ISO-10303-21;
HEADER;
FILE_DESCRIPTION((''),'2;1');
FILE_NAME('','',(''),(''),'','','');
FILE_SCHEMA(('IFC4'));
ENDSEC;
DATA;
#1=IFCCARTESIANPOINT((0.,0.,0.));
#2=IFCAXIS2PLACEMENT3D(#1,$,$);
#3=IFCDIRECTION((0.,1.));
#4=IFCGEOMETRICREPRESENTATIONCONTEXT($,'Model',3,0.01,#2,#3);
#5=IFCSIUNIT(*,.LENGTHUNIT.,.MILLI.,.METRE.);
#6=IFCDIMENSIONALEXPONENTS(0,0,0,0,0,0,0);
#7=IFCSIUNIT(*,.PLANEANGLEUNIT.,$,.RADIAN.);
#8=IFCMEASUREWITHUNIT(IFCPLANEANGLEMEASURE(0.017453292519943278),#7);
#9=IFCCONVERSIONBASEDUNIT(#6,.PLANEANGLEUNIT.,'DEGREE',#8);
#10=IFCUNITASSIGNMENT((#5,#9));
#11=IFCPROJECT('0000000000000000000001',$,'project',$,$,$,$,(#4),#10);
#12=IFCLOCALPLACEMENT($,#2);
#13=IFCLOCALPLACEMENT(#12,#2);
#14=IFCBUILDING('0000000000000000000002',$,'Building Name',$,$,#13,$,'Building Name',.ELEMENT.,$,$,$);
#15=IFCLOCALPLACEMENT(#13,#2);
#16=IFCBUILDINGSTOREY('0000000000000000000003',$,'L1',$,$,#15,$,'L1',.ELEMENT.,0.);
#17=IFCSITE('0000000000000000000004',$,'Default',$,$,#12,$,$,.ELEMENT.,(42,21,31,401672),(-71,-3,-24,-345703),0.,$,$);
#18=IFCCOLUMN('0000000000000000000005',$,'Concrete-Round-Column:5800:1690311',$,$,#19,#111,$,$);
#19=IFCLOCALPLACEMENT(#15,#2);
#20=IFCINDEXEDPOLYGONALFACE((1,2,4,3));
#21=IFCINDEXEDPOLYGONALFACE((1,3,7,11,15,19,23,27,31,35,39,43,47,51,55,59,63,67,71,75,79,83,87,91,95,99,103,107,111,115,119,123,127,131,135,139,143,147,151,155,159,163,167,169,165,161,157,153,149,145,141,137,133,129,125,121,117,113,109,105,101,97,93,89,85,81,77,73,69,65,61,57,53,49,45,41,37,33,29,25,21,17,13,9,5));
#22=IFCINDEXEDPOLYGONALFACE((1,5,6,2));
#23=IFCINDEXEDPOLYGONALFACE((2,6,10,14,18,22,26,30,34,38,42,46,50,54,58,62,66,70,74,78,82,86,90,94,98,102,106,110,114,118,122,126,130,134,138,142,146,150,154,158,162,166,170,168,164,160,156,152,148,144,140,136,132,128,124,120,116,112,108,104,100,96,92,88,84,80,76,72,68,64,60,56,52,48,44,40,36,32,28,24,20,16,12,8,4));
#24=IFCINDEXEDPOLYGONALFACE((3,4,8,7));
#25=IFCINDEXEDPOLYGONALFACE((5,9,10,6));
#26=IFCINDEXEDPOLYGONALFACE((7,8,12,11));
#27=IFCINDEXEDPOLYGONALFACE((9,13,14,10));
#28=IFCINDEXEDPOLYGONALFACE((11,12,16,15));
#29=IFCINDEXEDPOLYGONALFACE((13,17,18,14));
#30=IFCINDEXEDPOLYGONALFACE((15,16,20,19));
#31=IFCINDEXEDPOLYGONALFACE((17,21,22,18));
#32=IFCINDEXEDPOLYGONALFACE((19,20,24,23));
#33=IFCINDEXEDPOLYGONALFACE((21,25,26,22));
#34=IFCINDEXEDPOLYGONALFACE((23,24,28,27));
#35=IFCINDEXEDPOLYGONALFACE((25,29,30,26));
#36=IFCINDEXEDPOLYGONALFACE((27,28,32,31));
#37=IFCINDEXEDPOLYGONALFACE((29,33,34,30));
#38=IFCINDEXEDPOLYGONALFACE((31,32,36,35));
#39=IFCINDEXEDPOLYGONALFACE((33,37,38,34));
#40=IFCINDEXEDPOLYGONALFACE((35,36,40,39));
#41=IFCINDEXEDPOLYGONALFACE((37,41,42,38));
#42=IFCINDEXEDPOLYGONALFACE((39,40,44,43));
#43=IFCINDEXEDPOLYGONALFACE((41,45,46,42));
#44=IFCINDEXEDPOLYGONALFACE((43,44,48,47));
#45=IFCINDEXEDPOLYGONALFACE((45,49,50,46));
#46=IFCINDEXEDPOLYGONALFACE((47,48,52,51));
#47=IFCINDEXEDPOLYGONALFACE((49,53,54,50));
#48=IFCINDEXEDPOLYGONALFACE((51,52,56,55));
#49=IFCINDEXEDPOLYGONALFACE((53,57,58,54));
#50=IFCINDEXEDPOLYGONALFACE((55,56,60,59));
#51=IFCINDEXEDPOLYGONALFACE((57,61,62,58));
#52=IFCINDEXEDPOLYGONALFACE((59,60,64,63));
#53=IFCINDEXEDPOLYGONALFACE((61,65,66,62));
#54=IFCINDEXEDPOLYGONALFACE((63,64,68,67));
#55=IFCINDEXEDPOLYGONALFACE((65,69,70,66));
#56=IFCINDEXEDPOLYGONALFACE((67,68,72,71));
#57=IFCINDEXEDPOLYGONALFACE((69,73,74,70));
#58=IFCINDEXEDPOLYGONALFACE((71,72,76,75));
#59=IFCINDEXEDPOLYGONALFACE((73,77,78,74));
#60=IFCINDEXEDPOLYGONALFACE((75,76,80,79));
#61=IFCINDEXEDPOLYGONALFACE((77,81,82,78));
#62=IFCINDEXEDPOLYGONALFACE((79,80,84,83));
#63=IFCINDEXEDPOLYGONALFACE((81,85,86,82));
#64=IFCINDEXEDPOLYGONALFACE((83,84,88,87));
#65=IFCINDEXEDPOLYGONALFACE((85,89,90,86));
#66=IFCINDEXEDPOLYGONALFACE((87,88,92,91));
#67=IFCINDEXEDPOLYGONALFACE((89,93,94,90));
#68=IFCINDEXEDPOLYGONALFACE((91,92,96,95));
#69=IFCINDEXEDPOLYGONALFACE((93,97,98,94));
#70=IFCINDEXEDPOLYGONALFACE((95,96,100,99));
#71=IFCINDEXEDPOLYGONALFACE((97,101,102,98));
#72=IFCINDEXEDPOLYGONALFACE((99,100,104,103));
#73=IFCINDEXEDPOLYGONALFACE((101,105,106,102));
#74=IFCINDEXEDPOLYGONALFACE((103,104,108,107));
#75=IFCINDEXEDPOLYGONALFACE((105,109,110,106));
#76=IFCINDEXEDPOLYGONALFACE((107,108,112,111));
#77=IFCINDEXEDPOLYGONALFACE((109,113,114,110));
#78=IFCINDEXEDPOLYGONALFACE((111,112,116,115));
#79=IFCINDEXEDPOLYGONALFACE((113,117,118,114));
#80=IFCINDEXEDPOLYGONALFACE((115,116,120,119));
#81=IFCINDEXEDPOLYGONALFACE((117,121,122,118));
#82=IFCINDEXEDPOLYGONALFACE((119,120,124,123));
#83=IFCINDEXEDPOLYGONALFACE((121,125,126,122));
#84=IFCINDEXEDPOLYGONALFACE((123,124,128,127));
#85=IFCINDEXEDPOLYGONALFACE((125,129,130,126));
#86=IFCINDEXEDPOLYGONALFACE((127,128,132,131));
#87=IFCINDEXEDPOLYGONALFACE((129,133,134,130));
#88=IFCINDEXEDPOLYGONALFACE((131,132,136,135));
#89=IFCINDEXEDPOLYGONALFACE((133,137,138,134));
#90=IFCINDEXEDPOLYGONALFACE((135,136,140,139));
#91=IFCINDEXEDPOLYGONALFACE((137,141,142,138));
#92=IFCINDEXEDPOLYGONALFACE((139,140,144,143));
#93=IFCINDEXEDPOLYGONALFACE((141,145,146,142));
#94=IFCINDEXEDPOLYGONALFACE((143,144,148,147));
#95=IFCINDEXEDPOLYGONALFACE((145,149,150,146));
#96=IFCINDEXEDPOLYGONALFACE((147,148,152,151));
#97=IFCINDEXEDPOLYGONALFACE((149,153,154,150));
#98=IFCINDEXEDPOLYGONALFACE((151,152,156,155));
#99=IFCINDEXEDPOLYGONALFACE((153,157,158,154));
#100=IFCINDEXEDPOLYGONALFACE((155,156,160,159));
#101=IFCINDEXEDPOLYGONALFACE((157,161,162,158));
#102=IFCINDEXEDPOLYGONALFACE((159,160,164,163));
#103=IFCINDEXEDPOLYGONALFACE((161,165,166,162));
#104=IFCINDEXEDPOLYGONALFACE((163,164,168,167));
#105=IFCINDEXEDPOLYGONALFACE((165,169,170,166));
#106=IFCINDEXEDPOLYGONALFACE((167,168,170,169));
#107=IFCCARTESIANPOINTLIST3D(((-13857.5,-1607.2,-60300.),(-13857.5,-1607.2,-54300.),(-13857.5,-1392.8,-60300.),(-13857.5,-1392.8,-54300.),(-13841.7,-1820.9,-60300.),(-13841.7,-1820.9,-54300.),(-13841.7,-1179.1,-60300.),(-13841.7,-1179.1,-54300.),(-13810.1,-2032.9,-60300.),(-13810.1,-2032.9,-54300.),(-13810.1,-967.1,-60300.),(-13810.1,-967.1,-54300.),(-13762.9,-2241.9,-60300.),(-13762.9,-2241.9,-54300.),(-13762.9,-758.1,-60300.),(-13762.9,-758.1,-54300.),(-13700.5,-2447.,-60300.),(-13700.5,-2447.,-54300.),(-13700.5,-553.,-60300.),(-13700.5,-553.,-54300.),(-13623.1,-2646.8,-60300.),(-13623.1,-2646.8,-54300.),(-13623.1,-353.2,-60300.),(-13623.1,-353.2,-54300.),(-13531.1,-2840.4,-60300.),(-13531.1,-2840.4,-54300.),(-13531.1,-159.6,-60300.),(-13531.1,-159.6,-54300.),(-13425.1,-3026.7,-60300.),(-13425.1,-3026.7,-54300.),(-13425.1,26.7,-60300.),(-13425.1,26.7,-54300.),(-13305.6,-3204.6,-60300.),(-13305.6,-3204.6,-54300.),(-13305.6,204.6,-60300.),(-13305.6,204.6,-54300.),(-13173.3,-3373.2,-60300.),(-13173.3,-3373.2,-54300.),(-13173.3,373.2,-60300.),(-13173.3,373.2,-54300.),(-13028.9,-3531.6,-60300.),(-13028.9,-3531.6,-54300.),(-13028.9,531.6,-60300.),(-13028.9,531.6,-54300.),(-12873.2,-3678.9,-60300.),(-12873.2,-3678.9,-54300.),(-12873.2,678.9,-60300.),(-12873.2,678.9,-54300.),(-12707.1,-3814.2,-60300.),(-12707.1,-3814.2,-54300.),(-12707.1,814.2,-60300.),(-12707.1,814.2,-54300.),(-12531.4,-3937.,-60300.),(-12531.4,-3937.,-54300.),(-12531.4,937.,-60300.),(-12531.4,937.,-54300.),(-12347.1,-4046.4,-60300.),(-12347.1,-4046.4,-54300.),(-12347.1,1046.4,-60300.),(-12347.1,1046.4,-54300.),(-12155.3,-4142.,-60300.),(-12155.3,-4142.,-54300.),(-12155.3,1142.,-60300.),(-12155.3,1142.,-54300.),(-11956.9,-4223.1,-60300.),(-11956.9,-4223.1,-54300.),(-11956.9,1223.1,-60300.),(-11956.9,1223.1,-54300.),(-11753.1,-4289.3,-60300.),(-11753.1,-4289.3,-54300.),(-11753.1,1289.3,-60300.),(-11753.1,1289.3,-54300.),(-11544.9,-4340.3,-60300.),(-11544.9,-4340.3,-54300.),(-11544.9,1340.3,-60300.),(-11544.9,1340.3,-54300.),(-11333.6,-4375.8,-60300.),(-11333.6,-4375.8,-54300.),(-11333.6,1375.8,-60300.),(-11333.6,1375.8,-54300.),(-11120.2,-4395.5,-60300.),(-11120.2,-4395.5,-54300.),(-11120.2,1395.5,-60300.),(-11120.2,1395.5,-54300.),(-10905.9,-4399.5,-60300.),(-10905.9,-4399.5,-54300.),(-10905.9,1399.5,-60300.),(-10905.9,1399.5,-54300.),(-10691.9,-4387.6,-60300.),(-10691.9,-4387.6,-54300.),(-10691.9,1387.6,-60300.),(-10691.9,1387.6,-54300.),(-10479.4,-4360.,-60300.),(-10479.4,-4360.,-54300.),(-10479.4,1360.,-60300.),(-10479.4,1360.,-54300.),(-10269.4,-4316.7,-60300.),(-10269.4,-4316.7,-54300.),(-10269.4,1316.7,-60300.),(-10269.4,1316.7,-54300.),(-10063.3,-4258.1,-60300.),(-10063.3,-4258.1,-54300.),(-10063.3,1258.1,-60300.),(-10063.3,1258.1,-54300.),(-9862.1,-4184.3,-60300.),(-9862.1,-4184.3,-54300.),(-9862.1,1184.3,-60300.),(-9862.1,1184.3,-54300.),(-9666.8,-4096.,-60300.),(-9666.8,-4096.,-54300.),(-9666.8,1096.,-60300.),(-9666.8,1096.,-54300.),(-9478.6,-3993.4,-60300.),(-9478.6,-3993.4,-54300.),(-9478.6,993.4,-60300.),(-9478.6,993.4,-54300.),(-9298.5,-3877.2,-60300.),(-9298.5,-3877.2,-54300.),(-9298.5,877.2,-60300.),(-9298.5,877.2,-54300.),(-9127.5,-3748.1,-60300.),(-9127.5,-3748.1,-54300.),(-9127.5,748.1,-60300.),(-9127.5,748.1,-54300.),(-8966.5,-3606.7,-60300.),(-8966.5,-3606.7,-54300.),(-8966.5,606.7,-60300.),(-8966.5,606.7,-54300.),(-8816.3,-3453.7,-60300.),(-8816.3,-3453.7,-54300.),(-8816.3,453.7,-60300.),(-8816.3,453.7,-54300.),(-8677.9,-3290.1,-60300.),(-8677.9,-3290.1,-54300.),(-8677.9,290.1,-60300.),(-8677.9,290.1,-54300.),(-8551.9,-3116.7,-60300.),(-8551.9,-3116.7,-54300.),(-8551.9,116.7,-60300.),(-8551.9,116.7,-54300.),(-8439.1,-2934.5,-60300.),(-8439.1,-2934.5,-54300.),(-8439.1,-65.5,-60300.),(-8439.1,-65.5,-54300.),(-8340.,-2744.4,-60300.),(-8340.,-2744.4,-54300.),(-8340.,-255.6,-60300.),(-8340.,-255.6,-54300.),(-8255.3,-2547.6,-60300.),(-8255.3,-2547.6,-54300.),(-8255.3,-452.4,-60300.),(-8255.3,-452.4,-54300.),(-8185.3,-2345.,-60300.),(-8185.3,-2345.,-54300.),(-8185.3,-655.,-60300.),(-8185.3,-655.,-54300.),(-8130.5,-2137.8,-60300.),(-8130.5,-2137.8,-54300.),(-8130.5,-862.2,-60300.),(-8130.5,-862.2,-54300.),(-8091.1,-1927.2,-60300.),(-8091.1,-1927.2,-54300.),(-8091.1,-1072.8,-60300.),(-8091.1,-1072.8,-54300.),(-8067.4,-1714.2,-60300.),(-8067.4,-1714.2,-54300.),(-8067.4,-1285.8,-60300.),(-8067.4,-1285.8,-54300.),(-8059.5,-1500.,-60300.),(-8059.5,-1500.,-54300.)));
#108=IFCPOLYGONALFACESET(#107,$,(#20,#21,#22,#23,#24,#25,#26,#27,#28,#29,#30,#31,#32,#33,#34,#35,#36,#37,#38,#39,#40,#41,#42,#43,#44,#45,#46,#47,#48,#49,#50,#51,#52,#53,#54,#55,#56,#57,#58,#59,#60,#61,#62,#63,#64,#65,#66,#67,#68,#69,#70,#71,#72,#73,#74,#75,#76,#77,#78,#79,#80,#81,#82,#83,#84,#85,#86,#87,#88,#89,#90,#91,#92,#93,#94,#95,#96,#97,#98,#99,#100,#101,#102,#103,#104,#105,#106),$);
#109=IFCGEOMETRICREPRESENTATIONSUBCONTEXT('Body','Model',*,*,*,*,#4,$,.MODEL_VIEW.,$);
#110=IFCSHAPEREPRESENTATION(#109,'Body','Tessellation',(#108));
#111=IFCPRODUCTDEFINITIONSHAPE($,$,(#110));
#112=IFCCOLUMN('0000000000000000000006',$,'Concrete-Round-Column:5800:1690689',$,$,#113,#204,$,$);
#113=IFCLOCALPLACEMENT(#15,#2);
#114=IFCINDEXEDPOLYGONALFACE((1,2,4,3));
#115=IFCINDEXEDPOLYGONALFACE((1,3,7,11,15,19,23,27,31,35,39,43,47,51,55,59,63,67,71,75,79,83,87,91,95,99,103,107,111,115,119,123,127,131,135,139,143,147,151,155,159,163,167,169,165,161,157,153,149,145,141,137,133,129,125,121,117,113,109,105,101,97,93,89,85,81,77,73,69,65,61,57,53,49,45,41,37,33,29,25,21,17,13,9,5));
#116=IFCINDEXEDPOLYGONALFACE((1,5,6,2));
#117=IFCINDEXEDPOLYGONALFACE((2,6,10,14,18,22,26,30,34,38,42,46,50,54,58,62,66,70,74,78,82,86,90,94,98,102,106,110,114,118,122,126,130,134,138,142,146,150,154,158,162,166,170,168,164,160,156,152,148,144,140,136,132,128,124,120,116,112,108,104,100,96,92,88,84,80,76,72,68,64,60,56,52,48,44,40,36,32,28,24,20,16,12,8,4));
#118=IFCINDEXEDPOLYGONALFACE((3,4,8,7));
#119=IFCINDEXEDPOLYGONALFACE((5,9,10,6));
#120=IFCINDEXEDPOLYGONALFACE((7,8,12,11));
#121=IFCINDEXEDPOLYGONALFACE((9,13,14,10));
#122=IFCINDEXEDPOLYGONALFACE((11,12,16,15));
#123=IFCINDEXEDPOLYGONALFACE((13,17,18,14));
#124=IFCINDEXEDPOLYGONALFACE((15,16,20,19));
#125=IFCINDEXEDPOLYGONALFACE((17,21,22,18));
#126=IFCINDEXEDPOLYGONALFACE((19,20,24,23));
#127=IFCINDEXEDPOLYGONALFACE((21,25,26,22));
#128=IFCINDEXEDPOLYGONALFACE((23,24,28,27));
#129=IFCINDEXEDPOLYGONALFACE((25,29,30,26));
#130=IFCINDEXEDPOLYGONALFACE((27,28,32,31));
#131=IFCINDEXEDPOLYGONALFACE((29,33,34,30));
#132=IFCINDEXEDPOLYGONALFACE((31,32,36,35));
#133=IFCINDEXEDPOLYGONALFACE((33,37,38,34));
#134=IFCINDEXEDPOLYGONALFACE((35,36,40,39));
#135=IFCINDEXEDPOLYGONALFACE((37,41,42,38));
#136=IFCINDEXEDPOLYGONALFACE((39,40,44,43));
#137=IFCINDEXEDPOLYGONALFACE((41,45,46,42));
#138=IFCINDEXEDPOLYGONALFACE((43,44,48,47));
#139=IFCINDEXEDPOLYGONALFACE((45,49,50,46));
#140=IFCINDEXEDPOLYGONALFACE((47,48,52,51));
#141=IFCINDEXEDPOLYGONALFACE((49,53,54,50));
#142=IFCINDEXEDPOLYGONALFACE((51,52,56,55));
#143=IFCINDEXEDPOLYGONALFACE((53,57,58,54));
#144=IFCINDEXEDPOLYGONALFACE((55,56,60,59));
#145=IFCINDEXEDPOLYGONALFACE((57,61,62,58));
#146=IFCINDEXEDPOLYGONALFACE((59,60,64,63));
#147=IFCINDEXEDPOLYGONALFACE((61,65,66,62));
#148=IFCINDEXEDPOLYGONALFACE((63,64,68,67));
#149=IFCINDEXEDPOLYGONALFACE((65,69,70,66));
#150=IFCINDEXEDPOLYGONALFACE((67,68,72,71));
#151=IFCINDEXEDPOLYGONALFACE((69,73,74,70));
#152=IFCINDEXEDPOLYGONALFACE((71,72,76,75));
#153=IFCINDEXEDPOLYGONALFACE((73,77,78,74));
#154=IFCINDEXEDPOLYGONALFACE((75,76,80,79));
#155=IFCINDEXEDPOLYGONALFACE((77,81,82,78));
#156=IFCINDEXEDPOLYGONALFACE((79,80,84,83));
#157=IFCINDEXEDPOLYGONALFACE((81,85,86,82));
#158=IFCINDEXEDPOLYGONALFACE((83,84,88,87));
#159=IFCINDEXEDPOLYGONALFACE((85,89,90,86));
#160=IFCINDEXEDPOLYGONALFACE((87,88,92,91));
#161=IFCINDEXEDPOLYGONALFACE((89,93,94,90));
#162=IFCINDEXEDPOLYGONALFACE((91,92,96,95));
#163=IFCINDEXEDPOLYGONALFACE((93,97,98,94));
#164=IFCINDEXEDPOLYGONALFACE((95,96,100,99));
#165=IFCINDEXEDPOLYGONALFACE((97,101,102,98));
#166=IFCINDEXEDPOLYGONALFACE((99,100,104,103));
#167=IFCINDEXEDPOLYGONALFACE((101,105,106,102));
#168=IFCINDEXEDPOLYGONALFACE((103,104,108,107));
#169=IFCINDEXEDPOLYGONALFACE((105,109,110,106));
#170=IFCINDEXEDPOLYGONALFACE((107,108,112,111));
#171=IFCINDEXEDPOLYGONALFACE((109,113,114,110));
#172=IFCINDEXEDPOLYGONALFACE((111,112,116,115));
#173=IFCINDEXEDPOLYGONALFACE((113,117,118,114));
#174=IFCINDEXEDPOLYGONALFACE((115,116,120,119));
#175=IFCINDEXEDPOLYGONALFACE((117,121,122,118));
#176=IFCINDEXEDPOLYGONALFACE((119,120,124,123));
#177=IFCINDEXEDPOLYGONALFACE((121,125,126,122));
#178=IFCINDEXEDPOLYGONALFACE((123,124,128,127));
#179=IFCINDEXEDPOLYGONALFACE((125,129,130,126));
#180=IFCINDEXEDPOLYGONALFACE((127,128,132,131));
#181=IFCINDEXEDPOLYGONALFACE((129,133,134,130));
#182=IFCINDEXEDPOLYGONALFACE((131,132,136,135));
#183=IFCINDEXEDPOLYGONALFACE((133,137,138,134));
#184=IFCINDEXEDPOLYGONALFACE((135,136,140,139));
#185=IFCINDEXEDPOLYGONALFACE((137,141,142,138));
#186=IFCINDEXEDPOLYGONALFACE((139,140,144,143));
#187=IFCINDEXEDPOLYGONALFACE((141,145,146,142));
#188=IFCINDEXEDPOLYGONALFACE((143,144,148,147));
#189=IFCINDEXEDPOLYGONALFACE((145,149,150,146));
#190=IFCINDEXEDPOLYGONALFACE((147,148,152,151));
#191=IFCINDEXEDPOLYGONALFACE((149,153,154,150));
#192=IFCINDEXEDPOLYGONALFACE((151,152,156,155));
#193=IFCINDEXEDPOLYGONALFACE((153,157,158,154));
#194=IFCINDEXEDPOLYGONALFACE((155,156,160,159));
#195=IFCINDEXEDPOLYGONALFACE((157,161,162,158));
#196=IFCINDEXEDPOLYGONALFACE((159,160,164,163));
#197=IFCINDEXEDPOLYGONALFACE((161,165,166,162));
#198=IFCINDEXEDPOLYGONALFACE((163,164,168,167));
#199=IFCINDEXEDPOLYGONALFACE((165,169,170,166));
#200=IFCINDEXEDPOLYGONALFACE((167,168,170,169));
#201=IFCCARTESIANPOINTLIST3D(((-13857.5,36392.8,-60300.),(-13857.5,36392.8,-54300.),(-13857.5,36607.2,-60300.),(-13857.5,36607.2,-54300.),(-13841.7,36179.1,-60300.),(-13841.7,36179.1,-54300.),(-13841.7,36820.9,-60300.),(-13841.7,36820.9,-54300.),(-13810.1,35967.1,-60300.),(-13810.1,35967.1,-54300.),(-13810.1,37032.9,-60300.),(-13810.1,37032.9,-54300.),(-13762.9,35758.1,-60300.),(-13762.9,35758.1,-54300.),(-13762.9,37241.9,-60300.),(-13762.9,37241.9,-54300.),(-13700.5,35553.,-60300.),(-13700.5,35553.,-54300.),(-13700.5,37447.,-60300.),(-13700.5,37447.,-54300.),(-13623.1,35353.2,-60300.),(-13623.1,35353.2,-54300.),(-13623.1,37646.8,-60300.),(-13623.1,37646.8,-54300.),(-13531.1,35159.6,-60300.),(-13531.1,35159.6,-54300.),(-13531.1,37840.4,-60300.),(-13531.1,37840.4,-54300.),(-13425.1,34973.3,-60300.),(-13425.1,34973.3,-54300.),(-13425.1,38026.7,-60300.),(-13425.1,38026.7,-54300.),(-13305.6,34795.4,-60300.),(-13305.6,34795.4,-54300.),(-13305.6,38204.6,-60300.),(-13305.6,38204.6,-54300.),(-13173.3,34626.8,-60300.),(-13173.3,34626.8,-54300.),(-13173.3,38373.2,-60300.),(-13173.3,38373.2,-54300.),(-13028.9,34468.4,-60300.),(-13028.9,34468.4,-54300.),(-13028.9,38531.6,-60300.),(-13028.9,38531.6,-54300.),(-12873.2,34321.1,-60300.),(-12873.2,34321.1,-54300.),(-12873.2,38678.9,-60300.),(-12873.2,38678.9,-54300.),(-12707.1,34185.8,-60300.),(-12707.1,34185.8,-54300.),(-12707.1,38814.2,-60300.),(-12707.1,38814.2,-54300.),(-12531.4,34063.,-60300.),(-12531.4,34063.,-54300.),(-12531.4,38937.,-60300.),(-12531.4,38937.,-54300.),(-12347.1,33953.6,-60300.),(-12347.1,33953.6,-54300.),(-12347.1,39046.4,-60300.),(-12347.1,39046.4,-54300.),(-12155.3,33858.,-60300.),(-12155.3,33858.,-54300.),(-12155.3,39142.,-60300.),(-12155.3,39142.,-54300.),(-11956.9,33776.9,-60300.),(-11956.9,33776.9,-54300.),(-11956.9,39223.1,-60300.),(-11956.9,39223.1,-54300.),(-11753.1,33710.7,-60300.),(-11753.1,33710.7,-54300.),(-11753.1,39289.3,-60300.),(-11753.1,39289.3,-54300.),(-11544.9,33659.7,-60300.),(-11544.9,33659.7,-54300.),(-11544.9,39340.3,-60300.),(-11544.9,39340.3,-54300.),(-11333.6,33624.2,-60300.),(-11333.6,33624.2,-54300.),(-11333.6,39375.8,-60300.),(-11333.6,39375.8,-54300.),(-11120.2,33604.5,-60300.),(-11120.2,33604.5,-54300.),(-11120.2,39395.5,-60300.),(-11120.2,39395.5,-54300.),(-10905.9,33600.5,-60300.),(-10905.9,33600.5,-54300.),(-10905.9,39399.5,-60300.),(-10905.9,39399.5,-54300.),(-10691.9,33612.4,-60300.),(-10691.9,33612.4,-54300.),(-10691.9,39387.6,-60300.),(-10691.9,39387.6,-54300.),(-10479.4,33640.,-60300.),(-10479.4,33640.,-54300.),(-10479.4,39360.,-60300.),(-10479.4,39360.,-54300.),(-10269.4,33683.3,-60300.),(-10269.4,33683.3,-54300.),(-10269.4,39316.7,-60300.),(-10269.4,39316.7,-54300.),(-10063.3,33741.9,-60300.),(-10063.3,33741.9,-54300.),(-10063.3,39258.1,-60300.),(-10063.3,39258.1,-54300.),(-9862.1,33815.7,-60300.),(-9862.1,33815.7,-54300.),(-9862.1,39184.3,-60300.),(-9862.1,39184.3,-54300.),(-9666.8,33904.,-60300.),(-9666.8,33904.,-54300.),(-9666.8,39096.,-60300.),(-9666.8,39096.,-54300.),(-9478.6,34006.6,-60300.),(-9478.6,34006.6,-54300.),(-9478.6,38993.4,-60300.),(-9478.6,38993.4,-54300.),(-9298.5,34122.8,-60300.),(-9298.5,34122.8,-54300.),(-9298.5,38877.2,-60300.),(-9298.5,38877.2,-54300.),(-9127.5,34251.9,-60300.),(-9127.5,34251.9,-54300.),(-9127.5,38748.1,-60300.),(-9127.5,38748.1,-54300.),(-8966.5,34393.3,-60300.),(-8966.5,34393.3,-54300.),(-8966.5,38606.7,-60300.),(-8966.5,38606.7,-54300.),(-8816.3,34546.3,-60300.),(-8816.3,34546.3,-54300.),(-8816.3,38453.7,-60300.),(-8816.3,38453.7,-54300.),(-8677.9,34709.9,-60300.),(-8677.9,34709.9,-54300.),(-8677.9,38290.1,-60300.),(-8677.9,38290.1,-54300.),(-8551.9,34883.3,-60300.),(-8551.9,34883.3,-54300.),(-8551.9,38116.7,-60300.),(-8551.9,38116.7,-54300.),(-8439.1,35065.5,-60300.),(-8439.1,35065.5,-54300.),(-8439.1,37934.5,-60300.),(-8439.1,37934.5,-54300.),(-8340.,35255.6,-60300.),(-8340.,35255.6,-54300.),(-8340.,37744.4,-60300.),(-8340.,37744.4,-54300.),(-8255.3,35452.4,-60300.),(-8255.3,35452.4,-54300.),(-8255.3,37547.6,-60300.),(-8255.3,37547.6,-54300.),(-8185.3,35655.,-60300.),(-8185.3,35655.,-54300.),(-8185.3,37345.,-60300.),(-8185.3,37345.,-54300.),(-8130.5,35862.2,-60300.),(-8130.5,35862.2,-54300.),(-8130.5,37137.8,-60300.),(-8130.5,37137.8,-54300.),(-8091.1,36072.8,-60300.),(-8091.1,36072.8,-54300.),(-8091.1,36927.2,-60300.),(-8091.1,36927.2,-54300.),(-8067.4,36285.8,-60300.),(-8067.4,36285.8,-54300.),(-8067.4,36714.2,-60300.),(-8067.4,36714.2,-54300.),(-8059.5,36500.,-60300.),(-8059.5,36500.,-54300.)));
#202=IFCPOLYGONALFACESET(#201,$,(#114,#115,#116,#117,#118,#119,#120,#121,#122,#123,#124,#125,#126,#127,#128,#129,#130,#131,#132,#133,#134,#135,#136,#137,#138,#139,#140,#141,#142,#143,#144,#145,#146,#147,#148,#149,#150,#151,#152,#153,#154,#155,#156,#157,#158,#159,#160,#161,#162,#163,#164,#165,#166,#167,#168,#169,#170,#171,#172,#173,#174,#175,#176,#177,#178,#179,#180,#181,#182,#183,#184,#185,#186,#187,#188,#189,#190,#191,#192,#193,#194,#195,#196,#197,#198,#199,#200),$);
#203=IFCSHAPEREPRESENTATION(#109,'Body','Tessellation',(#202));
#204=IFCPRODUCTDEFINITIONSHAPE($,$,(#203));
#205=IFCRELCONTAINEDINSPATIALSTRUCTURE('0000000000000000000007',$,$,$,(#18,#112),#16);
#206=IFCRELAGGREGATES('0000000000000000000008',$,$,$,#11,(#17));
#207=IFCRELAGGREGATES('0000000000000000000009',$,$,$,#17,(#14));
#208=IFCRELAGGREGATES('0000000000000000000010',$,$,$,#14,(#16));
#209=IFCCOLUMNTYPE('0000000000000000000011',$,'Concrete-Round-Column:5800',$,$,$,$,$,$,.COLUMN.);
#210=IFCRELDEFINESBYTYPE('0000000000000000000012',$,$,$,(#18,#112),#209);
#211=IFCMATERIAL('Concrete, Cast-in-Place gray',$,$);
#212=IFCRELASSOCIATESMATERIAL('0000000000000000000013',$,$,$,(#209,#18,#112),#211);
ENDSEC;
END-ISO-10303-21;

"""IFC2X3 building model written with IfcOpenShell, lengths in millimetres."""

from ifc_helpers import new_model, entity, si_unit, converted_unit, direction, frame, frame_2d, origin, place, context, subcontext, project, spatial, circle, extrude, source, transform, mapped, material, type_object, type_shapes, element, save


model = new_model("IFC2X3")

# Units and contexts
model_context = context("Model", 3, precision=0.01, world=origin(), true_north=direction((0.0, 1.0)))
body_context = subcontext(model_context, "Body", "Model", "MODEL_VIEW")
ifc_project = project(units=[si_unit("LENGTHUNIT", "METRE", prefix="MILLI"), converted_unit("PLANEANGLEUNIT", "DEGREE", entity("IfcPlaneAngleMeasure", 0.017453292519943278), si_unit("PLANEANGLEUNIT", "RADIAN"), dimensions=[0, 0, 0, 0, 0, 0, 0])], contexts=[model_context])

# Site, building, storey
site_placement = place(None, origin())
site = spatial("IfcSite", under=ifc_project, at=site_placement, Name="Default", CompositionType="ELEMENT", RefLatitude=(42, 21, 31, 401672), RefLongitude=(-71, -3, -24, -345703), RefElevation=0.0)
building_placement = place(site_placement, origin())
building = spatial("IfcBuilding", under=site, at=building_placement, Name="Building Name", LongName="Building Name", CompositionType="ELEMENT")
storey_placement = place(building_placement, origin())
storey = spatial("IfcBuildingStorey", under=building, at=storey_placement, Name="L1", LongName="L1", CompositionType="ELEMENT", Elevation=0.0)

# Columns
ifc_material_1 = material(Name="Concrete, Cast-in-Place gray")
column_type_1 = type_object("IfcColumnType", Name="Concrete-Round-Column:5800", PredefinedType="COLUMN", material=ifc_material_1)
shared_shape_1 = source(origin(), body_context, "Body", "SweptSolid", [
    extrude(circle(Radius=2900.0, at=frame_2d((0.0, 0.0), x_axis=(1.0, 0.0))), frame((0.0, 0.0, -60300.0)), (0.0, 0.0, 1.0), 6000.0),
])
type_shapes(column_type_1, [shared_shape_1])
for number, where, name in (
    (1, (-10959.5, -1500.0, 0.0), "Concrete-Round-Column:5800:1690311"),
    (2, (-10959.5, 36500.0, 0.0), "Concrete-Round-Column:5800:1690689"),
):
    element("IfcColumn", number, at=place(storey_placement, frame(where)), inside=storey, type_object=column_type_1, material=ifc_material_1, Name=name, context=body_context, shape_type="MappedRepresentation", body=[
        mapped(shared_shape_1, transform((0.0, 0.0, 0.0), scale=1.0)),
    ])

save(model, "model.ifc")
